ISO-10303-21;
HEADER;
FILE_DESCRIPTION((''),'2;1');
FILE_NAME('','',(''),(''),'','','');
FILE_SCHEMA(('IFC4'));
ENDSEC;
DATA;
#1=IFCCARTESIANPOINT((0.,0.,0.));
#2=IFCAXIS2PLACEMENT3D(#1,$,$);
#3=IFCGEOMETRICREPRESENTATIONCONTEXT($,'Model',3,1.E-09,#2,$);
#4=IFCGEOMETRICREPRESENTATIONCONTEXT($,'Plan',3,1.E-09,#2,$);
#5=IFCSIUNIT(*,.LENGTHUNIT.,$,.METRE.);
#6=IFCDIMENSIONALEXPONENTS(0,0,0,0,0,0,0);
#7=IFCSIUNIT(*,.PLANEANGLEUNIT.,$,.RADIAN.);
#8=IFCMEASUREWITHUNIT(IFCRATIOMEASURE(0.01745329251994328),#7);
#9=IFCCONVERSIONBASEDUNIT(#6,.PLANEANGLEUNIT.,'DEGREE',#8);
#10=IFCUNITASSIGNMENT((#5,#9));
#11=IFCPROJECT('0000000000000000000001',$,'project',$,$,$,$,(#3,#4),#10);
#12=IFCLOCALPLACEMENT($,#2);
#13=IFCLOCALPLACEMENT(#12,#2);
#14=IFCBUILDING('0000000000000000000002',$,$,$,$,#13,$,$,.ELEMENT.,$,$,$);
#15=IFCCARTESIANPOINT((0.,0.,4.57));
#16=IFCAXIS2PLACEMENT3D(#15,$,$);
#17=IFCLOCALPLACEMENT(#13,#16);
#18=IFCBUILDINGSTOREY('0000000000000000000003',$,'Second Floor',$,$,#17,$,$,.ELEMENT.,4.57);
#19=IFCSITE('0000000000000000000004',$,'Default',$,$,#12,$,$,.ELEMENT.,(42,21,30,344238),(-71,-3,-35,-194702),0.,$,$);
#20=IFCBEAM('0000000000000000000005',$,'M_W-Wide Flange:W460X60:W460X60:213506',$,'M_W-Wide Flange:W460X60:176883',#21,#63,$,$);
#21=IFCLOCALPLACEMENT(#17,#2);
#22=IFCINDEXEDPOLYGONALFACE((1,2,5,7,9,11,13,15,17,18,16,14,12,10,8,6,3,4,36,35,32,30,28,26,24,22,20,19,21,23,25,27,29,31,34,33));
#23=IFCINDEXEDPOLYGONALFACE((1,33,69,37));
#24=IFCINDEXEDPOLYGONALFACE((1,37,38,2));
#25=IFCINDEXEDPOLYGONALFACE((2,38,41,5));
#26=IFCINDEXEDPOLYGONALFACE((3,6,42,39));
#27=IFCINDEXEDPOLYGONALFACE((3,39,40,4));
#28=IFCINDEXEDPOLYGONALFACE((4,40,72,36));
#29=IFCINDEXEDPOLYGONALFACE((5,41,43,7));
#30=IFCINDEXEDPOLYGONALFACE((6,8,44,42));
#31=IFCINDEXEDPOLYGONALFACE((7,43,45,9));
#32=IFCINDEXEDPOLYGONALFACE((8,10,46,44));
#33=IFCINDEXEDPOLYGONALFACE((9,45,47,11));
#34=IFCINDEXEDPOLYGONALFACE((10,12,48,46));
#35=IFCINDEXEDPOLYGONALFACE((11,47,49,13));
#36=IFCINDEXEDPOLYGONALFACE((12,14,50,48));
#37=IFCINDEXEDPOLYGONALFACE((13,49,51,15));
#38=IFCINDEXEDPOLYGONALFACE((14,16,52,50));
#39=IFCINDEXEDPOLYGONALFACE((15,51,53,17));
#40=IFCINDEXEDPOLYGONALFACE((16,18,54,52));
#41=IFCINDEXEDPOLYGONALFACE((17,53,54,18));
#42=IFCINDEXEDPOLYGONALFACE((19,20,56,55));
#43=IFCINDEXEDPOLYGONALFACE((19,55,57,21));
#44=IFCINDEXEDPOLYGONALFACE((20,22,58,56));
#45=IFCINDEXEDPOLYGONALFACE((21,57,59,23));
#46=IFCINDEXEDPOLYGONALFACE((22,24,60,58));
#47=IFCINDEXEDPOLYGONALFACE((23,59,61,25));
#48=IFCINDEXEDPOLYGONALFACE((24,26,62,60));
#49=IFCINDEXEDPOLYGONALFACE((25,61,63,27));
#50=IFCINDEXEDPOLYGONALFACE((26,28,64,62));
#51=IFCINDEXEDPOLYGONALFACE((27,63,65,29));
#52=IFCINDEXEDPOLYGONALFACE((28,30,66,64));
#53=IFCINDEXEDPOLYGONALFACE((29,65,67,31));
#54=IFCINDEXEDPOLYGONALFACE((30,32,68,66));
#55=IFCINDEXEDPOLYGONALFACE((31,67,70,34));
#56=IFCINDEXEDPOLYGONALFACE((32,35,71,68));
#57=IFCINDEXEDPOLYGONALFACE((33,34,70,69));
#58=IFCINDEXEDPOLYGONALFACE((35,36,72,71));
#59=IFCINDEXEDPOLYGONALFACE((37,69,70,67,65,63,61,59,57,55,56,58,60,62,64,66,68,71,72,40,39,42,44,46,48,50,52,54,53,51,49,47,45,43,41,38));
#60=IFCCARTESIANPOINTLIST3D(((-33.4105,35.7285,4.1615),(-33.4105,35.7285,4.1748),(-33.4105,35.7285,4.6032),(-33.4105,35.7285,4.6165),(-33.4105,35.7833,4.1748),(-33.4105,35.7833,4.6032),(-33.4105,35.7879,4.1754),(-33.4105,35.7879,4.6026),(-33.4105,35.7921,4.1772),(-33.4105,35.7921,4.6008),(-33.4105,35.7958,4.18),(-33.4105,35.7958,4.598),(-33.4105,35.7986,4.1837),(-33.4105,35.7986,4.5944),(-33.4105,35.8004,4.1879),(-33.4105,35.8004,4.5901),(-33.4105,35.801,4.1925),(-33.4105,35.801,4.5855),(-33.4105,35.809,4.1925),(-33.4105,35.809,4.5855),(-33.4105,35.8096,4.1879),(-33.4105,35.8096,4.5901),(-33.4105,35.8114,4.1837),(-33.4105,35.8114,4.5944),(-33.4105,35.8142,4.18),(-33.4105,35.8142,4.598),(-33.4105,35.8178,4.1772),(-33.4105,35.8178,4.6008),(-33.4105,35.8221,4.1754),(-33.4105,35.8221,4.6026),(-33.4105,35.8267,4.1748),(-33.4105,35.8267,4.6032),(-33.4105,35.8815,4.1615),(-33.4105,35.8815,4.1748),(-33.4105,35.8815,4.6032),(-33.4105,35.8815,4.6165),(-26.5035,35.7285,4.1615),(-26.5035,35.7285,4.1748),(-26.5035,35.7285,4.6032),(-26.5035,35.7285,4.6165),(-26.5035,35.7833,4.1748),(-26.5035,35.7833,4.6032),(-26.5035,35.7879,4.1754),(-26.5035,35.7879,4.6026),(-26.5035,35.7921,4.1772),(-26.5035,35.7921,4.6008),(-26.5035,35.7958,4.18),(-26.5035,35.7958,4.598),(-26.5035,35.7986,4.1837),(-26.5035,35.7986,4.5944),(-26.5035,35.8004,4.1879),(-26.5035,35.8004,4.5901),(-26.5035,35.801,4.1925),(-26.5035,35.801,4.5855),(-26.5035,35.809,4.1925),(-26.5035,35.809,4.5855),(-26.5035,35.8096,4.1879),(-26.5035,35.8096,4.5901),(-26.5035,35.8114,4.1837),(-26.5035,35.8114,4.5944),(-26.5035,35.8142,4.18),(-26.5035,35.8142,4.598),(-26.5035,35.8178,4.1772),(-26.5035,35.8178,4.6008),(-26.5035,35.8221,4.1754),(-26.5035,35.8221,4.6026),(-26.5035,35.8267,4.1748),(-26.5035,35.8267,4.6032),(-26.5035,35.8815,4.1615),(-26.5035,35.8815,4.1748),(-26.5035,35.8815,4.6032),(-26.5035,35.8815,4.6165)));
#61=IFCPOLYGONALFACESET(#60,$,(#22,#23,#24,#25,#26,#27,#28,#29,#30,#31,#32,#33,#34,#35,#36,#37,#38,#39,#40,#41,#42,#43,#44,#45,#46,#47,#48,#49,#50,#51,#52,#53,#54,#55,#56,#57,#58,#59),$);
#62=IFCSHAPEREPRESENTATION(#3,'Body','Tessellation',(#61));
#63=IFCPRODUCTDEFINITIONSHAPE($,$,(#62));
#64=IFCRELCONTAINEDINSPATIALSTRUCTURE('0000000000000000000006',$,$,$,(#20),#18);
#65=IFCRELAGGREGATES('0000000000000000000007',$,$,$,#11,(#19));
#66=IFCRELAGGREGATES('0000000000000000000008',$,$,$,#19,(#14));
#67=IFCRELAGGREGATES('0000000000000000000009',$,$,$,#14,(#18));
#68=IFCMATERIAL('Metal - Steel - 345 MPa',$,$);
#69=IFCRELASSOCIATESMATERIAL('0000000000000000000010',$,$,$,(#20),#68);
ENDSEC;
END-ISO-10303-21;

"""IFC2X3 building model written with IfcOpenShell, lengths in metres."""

from ifc_helpers import new_model, entity, si_unit, converted_unit, frame, frame_2d, origin, place, context, project, spatial, polyline, circle_curve, parameter, trimmed, segment, composite_curve, outline, extrude, material, element, save


model = new_model("IFC2X3")

# Units and contexts
model_context = context("Model", 3, precision=1e-09, world=origin())
plan_context = context("Plan", 3, precision=1e-09, world=origin())
ifc_project = project(units=[si_unit("LENGTHUNIT", "METRE"), converted_unit("PLANEANGLEUNIT", "DEGREE", entity("IfcRatioMeasure", 0.01745329251994328), si_unit("PLANEANGLEUNIT", "RADIAN"), dimensions=[0, 0, 0, 0, 0, 0, 0])], contexts=[model_context, plan_context])

# Site, building, storey
site_placement = place(None, origin())
site = spatial("IfcSite", under=ifc_project, at=site_placement, Name="Default", CompositionType="ELEMENT", RefLatitude=(42, 21, 30, 344238), RefLongitude=(-71, -3, -35, -194702), RefElevation=0.0)
building_placement = place(site_placement, origin())
building = spatial("IfcBuilding", under=site, at=building_placement, CompositionType="ELEMENT")
storey_placement = place(building_placement, frame((0.0, 0.0, 4.57)))
storey = spatial("IfcBuildingStorey", under=building, at=storey_placement, Name="Second Floor", CompositionType="ELEMENT", Elevation=4.57)

# Shared definitions
ifc_material = material(Name="Metal - Steel - 345 MPa")

# Beam
beam_1_placement = place(storey_placement, frame((-26.4403, 35.805, 4.6165), z_axis=(0.0, 0.0, 1.0), x_axis=(0.0, 1.0, 0.0)))
element("IfcBeam", 1, at=beam_1_placement, inside=storey, material=ifc_material, Name="M_W-Wide Flange:W460X60:W460X60:213506", ObjectType="M_W-Wide Flange:W460X60:176883", context=model_context, shape_type="SweptSolid", body=[
    extrude(outline(composite_curve([segment(polyline([(0.2142, -0.0765), (0.2275, -0.0765)]), True, "CONTINUOUS"), segment(polyline([(0.2275, -0.0765), (0.2275, 0.0765)]), True, "CONTINUOUS"), segment(polyline([(0.2275, 0.0765), (0.2142, 0.0765)]), True, "CONTINUOUS"), segment(polyline([(0.2142, 0.0765), (0.2142, 0.0217)]), True, "CONTINUOUS"), segment(trimmed(circle_curve(frame_2d((0.1965, 0.0217), x_axis=(0.0, 1.0)), 0.0177), [parameter(180.0)], [parameter(270.0)], True, "PARAMETER"), False, "CONTINUOUS"), segment(polyline([(0.1965, 0.004), (-0.1965, 0.004)]), True, "CONTINUOUS"), segment(trimmed(circle_curve(frame_2d((-0.1965, 0.0217), x_axis=(0.0, 1.0)), 0.0177), [parameter(90.0)], [parameter(180.0)], True, "PARAMETER"), False, "CONTINUOUS"), segment(polyline([(-0.2142, 0.0217), (-0.2142, 0.0765)]), True, "CONTINUOUS"), segment(polyline([(-0.2142, 0.0765), (-0.2275, 0.0765)]), True, "CONTINUOUS"), segment(polyline([(-0.2275, 0.0765), (-0.2275, -0.0765)]), True, "CONTINUOUS"), segment(polyline([(-0.2275, -0.0765), (-0.2142, -0.0765)]), True, "CONTINUOUS"), segment(polyline([(-0.2142, -0.0765), (-0.2142, -0.0217)]), True, "CONTINUOUS"), segment(trimmed(circle_curve(frame_2d((-0.1965, -0.0217), x_axis=(0.0, 1.0)), 0.0177), [parameter(360.0)], [parameter(90.0)], True, "PARAMETER"), False, "CONTINUOUS"), segment(polyline([(-0.1965, -0.004), (0.1965, -0.004)]), True, "CONTINUOUS"), segment(trimmed(circle_curve(frame_2d((0.1965, -0.0217), x_axis=(0.0, 1.0)), 0.0177), [parameter(270.0)], [parameter(0.0)], True, "PARAMETER"), False, "CONTINUOUS"), segment(polyline([(0.2142, -0.0217), (0.2142, -0.0765)]), True, "CONTINUOUS")], self_intersect=False)), frame((0.0, 6.9702, -0.2275), z_axis=(0.0, -1.0, 0.0), x_axis=(0.0, 0.0, -1.0)), (0.0, 0.0, 1.0), 6.907),
])

save(model, "model.ifc")
